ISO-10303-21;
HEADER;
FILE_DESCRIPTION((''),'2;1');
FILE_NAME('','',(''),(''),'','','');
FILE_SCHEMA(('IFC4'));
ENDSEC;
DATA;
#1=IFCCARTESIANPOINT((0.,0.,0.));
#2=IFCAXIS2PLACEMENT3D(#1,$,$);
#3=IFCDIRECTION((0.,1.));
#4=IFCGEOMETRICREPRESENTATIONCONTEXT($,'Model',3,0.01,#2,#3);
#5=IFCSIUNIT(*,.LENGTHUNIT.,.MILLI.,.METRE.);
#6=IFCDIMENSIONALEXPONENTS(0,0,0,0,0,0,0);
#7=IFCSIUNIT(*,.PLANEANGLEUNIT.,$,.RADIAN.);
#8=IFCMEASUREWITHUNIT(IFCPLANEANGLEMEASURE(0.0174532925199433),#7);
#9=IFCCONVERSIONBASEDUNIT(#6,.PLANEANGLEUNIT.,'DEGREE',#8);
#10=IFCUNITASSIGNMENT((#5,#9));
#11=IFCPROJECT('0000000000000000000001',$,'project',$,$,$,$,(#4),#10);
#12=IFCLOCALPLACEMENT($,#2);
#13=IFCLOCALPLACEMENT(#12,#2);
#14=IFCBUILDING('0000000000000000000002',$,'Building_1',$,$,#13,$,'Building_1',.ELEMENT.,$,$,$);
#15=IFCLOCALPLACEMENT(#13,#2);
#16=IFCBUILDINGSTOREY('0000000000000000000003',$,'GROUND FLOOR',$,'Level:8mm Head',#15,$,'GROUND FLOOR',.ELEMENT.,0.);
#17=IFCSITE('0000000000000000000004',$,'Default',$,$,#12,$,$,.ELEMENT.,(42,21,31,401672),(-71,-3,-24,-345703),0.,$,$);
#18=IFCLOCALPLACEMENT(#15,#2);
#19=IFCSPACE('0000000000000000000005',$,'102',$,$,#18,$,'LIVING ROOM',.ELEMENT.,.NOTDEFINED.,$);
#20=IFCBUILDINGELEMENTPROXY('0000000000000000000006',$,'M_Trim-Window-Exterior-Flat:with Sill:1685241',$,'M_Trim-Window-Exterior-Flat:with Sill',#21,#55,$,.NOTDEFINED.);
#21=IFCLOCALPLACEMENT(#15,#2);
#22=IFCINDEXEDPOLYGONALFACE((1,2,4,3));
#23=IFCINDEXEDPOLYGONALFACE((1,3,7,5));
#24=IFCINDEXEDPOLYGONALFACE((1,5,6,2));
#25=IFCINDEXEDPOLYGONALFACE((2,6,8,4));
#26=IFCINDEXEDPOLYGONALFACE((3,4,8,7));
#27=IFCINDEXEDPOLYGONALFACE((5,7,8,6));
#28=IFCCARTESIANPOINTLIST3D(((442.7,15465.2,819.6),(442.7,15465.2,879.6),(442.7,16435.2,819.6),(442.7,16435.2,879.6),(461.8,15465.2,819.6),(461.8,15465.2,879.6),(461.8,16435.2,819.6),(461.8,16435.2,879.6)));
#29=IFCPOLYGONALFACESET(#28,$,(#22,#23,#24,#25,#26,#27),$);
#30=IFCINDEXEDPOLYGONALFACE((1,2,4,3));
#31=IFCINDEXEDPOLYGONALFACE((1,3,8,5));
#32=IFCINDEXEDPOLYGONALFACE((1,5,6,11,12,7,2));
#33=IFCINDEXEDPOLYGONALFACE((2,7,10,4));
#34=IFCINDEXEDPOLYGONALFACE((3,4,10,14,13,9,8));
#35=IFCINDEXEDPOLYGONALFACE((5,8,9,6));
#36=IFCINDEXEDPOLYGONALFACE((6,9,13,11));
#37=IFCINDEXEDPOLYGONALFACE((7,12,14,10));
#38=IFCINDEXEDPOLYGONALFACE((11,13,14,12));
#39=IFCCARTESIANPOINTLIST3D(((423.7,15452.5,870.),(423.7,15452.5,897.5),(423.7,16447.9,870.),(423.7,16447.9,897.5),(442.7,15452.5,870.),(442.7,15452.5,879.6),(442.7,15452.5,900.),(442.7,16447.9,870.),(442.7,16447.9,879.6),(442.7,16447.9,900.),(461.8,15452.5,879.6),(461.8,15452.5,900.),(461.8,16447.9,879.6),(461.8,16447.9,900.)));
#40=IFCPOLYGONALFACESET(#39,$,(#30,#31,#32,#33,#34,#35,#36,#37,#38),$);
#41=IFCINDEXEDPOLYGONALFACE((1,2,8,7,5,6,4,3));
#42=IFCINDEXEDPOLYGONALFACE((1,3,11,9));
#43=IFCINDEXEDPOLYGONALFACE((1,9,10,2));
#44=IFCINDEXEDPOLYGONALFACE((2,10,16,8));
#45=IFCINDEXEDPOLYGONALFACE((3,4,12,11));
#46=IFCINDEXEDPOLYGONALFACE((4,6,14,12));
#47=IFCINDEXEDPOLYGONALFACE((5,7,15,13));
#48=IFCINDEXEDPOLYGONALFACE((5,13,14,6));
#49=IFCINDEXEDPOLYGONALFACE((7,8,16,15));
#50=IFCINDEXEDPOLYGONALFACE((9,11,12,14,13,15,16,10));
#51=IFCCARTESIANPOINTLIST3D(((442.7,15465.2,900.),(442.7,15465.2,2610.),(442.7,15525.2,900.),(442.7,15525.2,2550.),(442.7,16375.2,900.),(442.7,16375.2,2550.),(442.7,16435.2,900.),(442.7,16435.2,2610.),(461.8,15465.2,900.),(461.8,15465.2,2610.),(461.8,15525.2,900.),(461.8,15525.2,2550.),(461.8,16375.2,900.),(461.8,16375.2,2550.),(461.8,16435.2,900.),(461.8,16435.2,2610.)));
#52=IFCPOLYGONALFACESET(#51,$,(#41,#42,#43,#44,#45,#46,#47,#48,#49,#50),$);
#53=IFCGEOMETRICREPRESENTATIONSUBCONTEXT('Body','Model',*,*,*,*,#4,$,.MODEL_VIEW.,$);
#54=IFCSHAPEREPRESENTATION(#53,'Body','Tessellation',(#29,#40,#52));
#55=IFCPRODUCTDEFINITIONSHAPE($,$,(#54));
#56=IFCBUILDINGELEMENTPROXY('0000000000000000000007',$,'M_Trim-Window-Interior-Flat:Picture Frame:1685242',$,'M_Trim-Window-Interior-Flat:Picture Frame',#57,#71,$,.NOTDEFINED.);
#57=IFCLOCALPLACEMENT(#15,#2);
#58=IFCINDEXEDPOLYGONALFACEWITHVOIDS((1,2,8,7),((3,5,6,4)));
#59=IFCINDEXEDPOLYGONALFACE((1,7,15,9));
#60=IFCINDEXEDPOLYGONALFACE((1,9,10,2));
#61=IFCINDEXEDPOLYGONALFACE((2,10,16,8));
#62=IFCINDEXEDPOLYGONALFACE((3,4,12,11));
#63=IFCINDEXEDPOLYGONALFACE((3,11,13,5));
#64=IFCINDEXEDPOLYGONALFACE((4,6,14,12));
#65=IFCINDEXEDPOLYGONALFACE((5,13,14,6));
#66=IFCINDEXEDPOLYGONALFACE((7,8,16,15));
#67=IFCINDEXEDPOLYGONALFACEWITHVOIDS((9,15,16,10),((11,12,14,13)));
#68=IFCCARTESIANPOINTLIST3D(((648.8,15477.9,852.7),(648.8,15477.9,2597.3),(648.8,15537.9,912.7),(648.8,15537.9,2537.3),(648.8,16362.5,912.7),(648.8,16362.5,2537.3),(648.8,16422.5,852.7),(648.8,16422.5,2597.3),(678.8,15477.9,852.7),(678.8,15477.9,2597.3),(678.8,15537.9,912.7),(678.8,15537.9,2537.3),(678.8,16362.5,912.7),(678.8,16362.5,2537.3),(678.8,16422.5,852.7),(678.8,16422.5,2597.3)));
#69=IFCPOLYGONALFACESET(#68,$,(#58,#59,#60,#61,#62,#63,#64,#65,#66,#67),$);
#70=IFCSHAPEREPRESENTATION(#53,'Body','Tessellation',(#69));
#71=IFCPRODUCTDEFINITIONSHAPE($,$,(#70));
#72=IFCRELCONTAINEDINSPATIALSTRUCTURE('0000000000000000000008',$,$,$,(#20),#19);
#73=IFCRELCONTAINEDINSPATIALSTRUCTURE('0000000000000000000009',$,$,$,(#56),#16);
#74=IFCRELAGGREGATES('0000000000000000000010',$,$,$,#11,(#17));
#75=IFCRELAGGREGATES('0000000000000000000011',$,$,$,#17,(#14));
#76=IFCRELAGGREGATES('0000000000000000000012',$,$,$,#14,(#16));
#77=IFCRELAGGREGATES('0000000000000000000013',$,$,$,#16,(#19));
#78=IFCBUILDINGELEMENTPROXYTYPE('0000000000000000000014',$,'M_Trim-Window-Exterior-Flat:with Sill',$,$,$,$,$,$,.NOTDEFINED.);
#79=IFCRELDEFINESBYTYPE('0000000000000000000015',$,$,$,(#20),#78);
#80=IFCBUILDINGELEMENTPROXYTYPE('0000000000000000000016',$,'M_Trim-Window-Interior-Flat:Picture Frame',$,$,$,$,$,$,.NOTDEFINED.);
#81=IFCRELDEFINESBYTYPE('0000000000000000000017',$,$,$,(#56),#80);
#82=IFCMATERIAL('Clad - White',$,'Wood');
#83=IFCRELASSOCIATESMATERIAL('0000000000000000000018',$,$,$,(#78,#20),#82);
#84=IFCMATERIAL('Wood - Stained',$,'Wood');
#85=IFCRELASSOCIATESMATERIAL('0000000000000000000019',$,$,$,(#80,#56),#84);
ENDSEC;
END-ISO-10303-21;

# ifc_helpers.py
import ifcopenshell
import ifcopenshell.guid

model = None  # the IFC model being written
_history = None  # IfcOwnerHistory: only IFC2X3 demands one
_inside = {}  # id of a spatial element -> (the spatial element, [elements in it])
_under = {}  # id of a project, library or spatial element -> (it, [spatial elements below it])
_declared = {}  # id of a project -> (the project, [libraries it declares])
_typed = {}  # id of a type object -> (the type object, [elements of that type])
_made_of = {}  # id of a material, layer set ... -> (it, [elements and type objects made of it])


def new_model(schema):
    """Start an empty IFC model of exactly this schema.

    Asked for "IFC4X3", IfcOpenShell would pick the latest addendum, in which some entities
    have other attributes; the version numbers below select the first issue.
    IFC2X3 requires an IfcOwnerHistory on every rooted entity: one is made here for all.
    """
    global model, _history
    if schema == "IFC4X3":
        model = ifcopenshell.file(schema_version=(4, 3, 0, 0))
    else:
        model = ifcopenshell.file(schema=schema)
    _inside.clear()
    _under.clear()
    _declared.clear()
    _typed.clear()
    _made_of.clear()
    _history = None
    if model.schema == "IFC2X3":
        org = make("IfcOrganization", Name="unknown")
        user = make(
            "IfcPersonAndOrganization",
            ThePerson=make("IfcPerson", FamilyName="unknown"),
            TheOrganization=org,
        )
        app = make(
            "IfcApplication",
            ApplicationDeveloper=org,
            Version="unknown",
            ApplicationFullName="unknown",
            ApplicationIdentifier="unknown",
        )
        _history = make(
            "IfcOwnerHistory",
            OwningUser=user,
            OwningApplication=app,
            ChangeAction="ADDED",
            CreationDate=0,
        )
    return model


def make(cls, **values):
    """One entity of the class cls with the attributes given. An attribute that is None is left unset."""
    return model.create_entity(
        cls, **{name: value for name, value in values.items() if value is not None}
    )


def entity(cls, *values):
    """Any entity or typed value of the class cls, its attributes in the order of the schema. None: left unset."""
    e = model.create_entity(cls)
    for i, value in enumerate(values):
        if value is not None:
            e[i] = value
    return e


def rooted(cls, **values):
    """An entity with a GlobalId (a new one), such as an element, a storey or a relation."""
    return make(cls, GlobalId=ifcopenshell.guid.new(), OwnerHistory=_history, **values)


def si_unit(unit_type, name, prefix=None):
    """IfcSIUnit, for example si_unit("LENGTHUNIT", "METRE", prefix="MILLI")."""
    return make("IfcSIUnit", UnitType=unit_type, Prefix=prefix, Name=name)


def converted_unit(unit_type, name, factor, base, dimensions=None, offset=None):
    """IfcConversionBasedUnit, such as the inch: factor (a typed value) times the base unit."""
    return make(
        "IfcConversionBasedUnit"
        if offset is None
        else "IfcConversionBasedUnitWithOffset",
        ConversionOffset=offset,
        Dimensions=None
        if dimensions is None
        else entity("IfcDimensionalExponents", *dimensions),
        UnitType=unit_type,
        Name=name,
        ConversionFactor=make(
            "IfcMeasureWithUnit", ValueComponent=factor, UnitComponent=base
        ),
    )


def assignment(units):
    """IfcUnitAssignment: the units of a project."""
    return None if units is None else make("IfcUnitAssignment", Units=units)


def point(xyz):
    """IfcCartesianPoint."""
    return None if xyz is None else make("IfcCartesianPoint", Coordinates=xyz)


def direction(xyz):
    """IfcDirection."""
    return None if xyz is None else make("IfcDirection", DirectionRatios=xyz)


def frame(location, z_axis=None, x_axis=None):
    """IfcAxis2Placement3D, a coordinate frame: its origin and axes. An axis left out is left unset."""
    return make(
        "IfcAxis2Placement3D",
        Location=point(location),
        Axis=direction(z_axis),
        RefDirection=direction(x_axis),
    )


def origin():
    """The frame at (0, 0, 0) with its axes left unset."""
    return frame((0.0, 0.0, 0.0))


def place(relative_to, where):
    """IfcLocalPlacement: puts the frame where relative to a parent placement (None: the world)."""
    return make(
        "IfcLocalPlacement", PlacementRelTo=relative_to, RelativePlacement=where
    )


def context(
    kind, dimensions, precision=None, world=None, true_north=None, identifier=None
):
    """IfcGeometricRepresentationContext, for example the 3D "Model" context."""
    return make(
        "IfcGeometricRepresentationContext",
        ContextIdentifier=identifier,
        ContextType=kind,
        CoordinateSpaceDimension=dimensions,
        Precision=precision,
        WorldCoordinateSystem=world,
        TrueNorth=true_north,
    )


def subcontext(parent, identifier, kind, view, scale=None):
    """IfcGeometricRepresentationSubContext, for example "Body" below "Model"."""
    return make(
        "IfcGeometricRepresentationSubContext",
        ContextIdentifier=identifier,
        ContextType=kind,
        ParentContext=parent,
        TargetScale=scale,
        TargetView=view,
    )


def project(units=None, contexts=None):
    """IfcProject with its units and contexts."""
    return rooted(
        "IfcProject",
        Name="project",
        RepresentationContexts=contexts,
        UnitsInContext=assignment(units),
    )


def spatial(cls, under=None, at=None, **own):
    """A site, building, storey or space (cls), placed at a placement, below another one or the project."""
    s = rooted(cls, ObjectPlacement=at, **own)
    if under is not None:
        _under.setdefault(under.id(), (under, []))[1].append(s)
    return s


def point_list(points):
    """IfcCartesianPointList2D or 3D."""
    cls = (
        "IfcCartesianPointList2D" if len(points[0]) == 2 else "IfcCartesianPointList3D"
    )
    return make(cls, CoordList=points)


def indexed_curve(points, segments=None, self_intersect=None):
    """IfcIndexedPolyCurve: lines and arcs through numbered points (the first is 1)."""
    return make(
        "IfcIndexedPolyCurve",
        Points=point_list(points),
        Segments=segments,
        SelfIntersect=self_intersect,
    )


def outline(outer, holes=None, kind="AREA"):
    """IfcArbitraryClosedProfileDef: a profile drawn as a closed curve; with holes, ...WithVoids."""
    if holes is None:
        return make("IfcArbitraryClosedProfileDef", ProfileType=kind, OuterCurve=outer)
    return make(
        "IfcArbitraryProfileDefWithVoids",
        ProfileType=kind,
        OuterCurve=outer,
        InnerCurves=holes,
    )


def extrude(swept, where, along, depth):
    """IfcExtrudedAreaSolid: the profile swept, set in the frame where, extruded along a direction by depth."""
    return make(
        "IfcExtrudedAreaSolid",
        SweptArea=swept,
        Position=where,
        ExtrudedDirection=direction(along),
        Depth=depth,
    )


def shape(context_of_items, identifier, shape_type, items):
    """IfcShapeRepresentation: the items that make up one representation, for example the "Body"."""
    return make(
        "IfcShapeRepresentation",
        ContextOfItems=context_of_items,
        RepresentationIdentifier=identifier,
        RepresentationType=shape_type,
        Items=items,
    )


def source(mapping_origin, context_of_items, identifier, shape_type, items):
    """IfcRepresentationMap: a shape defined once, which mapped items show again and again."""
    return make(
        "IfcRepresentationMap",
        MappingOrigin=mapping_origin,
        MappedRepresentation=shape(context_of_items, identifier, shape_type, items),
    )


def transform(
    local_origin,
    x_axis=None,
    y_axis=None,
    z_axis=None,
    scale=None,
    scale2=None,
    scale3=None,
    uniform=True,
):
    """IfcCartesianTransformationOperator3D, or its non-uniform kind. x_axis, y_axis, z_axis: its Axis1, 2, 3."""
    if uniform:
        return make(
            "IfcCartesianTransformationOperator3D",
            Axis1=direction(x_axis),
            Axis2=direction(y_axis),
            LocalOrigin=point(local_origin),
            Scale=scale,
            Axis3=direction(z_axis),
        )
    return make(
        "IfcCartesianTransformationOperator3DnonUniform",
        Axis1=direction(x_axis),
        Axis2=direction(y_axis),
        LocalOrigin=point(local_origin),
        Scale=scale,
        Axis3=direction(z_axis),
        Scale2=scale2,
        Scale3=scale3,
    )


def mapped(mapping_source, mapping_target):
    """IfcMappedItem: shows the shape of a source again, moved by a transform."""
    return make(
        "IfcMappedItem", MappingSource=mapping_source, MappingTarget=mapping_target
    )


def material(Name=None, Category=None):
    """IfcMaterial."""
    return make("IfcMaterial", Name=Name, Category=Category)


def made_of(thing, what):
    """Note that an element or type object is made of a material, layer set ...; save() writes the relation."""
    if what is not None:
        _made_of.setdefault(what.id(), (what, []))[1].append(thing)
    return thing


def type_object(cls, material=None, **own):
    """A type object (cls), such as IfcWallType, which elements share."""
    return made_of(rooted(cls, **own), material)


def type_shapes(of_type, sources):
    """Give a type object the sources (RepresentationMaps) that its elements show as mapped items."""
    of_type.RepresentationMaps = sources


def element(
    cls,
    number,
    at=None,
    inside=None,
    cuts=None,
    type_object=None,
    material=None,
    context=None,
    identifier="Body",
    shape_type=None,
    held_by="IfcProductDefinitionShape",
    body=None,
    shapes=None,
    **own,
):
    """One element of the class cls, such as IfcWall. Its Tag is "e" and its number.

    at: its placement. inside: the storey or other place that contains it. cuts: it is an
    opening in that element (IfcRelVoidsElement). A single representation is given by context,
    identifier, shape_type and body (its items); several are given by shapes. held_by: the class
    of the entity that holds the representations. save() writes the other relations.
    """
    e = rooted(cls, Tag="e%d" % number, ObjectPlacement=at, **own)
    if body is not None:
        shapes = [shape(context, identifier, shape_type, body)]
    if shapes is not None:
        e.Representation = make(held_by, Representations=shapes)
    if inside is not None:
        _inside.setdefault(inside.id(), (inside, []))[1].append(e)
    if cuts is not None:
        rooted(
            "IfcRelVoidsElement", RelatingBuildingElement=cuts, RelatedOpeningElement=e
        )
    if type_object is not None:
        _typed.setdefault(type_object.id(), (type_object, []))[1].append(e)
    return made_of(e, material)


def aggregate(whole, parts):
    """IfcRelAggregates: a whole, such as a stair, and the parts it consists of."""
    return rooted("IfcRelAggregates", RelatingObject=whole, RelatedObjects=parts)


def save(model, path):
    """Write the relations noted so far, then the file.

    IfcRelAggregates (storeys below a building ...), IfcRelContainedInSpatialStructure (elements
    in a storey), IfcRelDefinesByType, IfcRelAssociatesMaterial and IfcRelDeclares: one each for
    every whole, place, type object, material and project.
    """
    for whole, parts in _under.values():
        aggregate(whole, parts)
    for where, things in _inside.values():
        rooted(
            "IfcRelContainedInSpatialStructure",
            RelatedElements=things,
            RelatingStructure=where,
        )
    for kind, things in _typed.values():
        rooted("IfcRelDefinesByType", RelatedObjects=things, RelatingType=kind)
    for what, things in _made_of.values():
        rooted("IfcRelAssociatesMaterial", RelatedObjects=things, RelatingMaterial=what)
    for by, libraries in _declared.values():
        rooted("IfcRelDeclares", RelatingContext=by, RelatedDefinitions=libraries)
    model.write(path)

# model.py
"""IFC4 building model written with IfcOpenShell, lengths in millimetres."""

from ifc_helpers import new_model, entity, si_unit, converted_unit, direction, frame, origin, place, context, subcontext, project, spatial, indexed_curve, outline, extrude, source, transform, mapped, material, type_object, type_shapes, element, save


model = new_model("IFC4")

# Units and contexts
model_context = context("Model", 3, precision=0.01, world=origin(), true_north=direction((0.0, 1.0)))
body_context = subcontext(model_context, "Body", "Model", "MODEL_VIEW")
ifc_project = project(units=[si_unit("LENGTHUNIT", "METRE", prefix="MILLI"), converted_unit("PLANEANGLEUNIT", "DEGREE", entity("IfcPlaneAngleMeasure", 0.0174532925199433), si_unit("PLANEANGLEUNIT", "RADIAN"), dimensions=[0, 0, 0, 0, 0, 0, 0])], contexts=[model_context])

# Site, building, storey
site_placement = place(None, origin())
site = spatial("IfcSite", under=ifc_project, at=site_placement, Name="Default", CompositionType="ELEMENT", RefLatitude=(42, 21, 31, 401672), RefLongitude=(-71, -3, -24, -345703), RefElevation=0.0)
building_placement = place(site_placement, origin())
building = spatial("IfcBuilding", under=site, at=building_placement, Name="Building_1", LongName="Building_1", CompositionType="ELEMENT")
storey_placement = place(building_placement, origin())
storey = spatial("IfcBuildingStorey", under=building, at=storey_placement, Name="GROUND FLOOR", ObjectType="Level:8mm Head", LongName="GROUND FLOOR", CompositionType="ELEMENT", Elevation=0.0)

# Shared definitions
ifc_material_1 = material(Name="Wood - Stained", Category="Wood")

# Shared definitions
ifc_material_2 = material(Name="Clad - White", Category="Wood")

# Shared definitions
space_1_placement = place(storey_placement, origin())
space_1 = spatial("IfcSpace", under=storey, at=space_1_placement, Name="102", LongName="LIVING ROOM", CompositionType="ELEMENT", PredefinedType="NOTDEFINED")

# Building element proxies
building_element_proxy_type_1 = type_object("IfcBuildingElementProxyType", Name="M_Trim-Window-Exterior-Flat:with Sill", PredefinedType="NOTDEFINED", material=ifc_material_2)
shared_shape_1 = source(origin(), body_context, "Body", "SweptSolid", [
    extrude(outline(indexed_curve([(-485.0, -30.0), (485.0, -30.0), (485.0, 30.0), (-485.0, 30.0), (-485.0, -30.0)], self_intersect=False)), frame((0.0, -1700.4, 0.0), z_axis=(0.0, 0.0, 1.0), x_axis=(-1.0, 0.0, 0.0)), (0.0, 0.0, 1.0), 19.1),
    extrude(outline(indexed_curve([(-19.0, -15.2), (0.0, -15.2), (0.0, -5.7), (19.0, -5.7), (19.0, 14.8), (0.0, 14.8), (-19.0, 12.3), (-19.0, -15.2)], self_intersect=False)), frame((-497.7, -1664.8, 19.0), z_axis=(1.0, 0.0, 0.0), x_axis=(0.0, 0.0, -1.0)), (0.0, 0.0, 1.0), 995.4),
    extrude(outline(indexed_curve([(-870.0, -485.0), (840.0, -485.0), (840.0, -425.0), (-810.0, -425.0), (-810.0, 425.0), (840.0, 425.0), (840.0, 485.0), (-870.0, 485.0), (-870.0, -485.0)], self_intersect=False)), frame((0.0, -810.0, 0.0), z_axis=(0.0, 0.0, 1.0), x_axis=(0.0, -1.0, 0.0)), (0.0, 0.0, 1.0), 19.1),
])
type_shapes(building_element_proxy_type_1, [shared_shape_1])
proxy_1_placement = place(space_1_placement, frame((461.8, 15950.2, 2550.0), z_axis=(-1.0, 0.0, 0.0), x_axis=(0.0, -1.0, 0.0)))
element("IfcBuildingElementProxy", 1, at=proxy_1_placement, inside=space_1, type_object=building_element_proxy_type_1, material=ifc_material_2, Name="M_Trim-Window-Exterior-Flat:with Sill:1685241", ObjectType="M_Trim-Window-Exterior-Flat:with Sill", PredefinedType="NOTDEFINED", context=body_context, shape_type="MappedRepresentation", body=[
    mapped(shared_shape_1, transform((0.0, 0.0, 0.0), scale=1.0)),
])
building_element_proxy_type_2 = type_object("IfcBuildingElementProxyType", Name="M_Trim-Window-Interior-Flat:Picture Frame", PredefinedType="NOTDEFINED", material=ifc_material_1)
shared_shape_2 = source(origin(), body_context, "Body", "SweptSolid", [
    extrude(outline(indexed_curve([(-472.3, -872.3), (472.3, -872.3), (472.3, 872.3), (-472.3, 872.3), (-472.3, -872.3)], self_intersect=False), holes=[indexed_curve([(-412.3, -812.3), (-412.3, 812.3), (412.3, 812.3), (412.3, -812.3), (-412.3, -812.3)], self_intersect=False)]), frame((0.0, -825.0, 0.0), z_axis=(0.0, 0.0, 1.0), x_axis=(-1.0, 0.0, 0.0)), (0.0, 0.0, 1.0), 30.0),
])
type_shapes(building_element_proxy_type_2, [shared_shape_2])
proxy_2_placement = place(storey_placement, frame((648.8, 15950.2, 2550.0), z_axis=(1.0, 0.0, 0.0), x_axis=(0.0, 1.0, 0.0)))
element("IfcBuildingElementProxy", 2, at=proxy_2_placement, inside=storey, type_object=building_element_proxy_type_2, material=ifc_material_1, Name="M_Trim-Window-Interior-Flat:Picture Frame:1685242", ObjectType="M_Trim-Window-Interior-Flat:Picture Frame", PredefinedType="NOTDEFINED", context=body_context, shape_type="MappedRepresentation", body=[
    mapped(shared_shape_2, transform((0.0, 0.0, 0.0), scale=1.0)),
])

save(model, "model.ifc")
